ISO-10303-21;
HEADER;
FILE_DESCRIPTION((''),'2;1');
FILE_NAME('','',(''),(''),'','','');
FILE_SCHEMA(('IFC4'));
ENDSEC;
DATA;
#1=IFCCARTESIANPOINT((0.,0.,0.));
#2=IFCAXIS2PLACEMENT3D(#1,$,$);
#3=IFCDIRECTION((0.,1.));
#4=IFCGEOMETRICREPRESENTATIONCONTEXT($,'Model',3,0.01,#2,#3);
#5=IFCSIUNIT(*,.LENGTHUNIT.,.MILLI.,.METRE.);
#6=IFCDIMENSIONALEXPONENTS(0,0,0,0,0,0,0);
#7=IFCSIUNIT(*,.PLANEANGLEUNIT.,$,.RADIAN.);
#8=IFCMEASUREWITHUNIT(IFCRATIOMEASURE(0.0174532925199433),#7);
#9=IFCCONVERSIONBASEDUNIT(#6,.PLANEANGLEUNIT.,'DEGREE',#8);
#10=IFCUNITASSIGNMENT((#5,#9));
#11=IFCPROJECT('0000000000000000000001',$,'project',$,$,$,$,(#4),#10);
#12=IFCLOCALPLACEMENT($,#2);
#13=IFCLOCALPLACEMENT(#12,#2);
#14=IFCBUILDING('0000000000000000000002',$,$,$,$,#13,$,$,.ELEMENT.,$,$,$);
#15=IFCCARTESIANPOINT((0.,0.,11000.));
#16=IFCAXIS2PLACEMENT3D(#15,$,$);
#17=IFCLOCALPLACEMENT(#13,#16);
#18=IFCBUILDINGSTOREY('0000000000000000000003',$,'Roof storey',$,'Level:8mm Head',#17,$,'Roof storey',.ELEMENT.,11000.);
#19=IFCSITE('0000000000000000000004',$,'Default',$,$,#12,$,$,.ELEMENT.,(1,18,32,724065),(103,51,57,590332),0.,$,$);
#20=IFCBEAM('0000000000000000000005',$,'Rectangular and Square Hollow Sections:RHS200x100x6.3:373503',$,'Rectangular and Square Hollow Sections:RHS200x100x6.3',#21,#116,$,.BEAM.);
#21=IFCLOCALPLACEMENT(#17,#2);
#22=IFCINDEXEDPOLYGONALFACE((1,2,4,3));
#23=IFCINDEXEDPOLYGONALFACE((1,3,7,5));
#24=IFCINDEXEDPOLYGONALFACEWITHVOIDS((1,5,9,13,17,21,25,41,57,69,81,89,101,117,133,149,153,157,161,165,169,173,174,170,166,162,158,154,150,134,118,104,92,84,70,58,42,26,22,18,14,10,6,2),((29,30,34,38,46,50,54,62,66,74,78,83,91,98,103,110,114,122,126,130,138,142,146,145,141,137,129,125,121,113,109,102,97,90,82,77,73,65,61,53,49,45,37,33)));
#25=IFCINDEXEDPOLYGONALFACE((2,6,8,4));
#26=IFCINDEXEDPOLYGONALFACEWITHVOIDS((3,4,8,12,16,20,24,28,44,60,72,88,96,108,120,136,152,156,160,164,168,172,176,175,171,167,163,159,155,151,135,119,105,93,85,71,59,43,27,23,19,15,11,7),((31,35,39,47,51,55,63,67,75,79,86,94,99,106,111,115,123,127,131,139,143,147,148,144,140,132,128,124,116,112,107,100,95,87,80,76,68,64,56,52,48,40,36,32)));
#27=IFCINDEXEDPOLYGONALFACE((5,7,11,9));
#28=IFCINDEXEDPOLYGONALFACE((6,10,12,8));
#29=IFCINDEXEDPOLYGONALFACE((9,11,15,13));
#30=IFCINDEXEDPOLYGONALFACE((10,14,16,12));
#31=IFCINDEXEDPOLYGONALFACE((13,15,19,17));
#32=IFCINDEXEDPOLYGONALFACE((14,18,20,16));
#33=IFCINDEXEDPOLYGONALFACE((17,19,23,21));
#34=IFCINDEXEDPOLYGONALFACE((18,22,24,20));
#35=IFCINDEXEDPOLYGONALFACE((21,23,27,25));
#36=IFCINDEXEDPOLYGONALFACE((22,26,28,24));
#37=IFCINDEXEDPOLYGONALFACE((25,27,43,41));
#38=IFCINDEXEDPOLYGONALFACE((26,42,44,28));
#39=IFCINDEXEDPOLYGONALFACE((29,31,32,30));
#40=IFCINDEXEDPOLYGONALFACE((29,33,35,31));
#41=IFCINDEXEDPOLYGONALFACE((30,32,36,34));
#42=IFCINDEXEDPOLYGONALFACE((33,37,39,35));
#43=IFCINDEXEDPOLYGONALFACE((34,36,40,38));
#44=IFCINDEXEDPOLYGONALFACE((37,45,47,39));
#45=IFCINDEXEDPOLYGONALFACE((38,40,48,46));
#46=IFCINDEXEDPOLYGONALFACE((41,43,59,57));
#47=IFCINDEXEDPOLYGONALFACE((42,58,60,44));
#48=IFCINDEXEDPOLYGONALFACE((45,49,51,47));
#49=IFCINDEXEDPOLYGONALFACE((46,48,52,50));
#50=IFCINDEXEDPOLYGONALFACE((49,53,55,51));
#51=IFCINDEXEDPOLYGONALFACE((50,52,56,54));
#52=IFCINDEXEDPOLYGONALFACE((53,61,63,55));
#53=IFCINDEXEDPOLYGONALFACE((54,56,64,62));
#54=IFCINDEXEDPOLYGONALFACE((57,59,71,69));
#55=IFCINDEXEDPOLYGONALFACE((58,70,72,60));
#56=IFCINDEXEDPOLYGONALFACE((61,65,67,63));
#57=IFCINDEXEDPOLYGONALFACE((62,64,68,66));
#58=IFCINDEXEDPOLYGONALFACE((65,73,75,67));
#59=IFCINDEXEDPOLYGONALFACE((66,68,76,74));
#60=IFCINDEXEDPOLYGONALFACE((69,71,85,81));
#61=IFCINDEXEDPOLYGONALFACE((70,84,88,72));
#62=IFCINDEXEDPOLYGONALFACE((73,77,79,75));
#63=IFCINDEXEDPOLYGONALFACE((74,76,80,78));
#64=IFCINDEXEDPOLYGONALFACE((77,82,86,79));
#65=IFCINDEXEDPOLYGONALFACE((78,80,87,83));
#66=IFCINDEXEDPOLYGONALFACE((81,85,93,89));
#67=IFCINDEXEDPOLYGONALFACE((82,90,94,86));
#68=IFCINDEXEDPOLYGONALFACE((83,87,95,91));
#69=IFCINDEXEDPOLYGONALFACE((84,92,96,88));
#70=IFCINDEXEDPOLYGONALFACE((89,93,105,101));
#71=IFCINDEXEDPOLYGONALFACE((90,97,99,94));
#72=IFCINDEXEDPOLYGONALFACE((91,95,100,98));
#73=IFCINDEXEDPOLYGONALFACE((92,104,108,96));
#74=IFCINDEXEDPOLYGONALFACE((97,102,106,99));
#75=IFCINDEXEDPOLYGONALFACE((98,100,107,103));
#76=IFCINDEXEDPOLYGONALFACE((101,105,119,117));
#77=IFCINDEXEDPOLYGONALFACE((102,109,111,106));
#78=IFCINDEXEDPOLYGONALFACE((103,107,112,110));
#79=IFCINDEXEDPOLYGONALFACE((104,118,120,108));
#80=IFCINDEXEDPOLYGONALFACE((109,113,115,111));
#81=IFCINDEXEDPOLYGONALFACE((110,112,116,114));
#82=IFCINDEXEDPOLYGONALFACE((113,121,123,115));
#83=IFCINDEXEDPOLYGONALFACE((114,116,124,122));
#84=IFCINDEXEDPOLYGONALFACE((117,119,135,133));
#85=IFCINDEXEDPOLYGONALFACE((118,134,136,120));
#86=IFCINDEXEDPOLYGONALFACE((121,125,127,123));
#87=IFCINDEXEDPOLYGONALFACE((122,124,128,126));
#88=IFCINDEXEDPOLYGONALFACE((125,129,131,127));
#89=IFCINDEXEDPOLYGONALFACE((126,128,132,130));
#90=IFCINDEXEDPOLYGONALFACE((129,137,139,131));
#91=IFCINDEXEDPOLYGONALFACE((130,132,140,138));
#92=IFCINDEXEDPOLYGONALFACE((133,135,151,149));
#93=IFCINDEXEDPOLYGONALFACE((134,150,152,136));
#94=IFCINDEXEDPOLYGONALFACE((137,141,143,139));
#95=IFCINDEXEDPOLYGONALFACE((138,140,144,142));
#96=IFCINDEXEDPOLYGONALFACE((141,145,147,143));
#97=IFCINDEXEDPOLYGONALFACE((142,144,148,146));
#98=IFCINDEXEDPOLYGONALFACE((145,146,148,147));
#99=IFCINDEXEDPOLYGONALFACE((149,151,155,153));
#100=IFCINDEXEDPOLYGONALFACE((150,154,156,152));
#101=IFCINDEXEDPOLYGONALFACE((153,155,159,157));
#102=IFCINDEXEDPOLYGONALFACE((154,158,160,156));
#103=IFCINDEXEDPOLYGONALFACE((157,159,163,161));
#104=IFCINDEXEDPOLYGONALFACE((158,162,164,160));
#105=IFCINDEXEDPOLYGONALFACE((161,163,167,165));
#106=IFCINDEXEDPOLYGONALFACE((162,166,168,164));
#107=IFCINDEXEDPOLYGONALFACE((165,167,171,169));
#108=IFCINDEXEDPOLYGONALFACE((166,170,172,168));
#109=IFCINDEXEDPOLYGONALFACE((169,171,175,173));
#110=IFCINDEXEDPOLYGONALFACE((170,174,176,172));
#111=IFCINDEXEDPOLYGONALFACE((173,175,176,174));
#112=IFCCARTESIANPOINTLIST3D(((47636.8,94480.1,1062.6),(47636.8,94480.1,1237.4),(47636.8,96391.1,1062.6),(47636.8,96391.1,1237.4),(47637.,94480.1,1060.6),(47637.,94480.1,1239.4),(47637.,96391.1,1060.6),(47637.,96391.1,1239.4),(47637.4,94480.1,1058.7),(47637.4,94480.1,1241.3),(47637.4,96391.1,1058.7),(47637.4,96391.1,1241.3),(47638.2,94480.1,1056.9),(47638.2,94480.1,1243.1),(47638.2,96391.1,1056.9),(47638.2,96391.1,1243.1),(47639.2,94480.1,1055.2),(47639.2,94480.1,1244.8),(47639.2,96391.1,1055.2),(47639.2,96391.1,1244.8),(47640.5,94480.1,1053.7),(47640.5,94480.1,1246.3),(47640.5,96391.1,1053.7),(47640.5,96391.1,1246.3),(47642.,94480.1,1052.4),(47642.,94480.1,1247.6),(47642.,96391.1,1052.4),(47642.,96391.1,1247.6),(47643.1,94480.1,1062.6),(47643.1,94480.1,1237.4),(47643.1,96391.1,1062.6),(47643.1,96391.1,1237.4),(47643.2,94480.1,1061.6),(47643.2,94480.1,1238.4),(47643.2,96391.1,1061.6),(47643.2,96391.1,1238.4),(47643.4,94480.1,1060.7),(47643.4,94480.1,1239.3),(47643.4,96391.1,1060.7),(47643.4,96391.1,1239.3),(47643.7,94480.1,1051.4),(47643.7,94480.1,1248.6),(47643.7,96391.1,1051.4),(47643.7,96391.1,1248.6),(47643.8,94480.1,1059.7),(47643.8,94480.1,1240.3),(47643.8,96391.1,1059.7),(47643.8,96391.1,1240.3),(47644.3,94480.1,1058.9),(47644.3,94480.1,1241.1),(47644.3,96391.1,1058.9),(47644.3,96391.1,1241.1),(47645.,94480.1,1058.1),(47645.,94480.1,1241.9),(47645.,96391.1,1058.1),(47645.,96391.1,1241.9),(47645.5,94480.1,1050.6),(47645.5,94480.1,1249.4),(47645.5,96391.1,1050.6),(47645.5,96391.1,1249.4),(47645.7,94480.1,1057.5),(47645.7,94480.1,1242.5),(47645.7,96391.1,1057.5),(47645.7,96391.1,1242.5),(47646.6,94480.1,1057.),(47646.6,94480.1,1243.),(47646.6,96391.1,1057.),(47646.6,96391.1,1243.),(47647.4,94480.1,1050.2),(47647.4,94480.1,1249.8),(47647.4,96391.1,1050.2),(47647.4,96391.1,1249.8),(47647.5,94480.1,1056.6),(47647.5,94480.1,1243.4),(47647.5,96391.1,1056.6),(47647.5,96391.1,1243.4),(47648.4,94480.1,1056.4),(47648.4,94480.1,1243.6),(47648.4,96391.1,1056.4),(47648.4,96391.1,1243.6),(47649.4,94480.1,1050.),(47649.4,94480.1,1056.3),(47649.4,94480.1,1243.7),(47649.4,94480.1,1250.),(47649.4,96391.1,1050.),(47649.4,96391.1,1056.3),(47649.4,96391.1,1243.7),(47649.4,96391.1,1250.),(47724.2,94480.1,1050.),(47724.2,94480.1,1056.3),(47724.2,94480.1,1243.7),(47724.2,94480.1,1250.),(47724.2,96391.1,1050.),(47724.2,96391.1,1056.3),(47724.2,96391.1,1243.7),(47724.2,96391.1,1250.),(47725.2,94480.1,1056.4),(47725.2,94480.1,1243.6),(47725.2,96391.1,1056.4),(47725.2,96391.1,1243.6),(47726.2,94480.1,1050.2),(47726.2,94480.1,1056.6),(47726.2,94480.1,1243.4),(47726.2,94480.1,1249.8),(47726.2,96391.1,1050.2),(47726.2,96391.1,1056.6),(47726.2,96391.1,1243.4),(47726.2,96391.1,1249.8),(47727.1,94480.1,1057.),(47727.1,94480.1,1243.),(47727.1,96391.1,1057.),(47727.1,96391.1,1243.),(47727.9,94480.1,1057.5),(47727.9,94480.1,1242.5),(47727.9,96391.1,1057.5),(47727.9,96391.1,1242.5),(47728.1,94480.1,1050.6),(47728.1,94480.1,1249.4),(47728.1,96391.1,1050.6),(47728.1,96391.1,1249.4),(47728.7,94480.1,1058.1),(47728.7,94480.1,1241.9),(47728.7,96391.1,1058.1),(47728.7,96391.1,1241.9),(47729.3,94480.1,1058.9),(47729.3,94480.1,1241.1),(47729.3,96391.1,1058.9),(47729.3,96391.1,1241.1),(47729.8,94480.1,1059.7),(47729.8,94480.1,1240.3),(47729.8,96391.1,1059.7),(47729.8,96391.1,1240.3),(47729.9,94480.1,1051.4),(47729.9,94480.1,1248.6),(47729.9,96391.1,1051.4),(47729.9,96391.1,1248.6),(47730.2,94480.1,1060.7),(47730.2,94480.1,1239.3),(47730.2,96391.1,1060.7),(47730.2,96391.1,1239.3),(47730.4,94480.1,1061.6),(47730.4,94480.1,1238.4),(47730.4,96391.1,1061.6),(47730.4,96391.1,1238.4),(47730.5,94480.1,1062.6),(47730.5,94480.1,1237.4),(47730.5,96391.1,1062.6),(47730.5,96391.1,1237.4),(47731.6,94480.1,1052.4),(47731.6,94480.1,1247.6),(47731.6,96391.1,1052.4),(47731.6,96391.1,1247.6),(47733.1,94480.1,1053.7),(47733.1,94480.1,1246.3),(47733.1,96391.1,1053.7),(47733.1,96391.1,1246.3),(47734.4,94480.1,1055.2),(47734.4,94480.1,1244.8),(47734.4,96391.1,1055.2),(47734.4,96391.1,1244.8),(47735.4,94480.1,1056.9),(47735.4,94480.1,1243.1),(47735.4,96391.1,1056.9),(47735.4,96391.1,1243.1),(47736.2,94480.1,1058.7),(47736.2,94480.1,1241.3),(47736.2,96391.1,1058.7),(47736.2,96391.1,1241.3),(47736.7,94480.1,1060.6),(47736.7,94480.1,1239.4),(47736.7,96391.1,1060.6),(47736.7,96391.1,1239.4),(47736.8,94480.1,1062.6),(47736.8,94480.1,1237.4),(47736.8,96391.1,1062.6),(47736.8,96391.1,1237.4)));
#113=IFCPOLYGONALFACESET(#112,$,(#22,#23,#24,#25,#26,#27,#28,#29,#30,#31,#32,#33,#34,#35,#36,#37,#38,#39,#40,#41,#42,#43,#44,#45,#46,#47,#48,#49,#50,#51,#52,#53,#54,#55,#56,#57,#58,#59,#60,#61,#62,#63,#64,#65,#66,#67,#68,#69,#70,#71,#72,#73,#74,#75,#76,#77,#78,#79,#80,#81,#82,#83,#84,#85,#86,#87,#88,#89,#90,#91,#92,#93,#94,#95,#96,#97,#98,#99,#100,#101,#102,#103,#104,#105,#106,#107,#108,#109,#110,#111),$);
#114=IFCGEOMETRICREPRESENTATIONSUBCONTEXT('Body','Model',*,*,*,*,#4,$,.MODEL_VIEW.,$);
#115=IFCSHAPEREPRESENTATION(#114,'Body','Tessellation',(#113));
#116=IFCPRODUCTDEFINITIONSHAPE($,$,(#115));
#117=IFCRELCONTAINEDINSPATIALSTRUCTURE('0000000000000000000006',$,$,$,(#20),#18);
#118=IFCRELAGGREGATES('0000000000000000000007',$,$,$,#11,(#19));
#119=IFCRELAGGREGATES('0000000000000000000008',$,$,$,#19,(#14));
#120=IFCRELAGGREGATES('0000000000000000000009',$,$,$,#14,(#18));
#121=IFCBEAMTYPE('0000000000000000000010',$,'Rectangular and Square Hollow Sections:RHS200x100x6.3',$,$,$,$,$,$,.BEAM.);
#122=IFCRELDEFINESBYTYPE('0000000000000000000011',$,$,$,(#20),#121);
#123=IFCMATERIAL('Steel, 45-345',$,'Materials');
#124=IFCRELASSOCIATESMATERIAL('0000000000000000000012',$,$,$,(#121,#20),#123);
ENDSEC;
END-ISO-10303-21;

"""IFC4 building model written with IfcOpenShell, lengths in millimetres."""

from ifc_helpers import new_model, entity, si_unit, converted_unit, direction, frame, origin, place, context, subcontext, project, spatial, indexed_curve, outline, extrude, source, transform, mapped, material, type_object, type_shapes, element, save


model = new_model("IFC4")

# Units and contexts
model_context = context("Model", 3, precision=0.01, world=origin(), true_north=direction((0.0, 1.0)))
body_context = subcontext(model_context, "Body", "Model", "MODEL_VIEW")
ifc_project = project(units=[si_unit("LENGTHUNIT", "METRE", prefix="MILLI"), converted_unit("PLANEANGLEUNIT", "DEGREE", entity("IfcRatioMeasure", 0.0174532925199433), si_unit("PLANEANGLEUNIT", "RADIAN"), dimensions=[0, 0, 0, 0, 0, 0, 0])], contexts=[model_context])

# Site, building, storey
site_placement = place(None, origin())
site = spatial("IfcSite", under=ifc_project, at=site_placement, Name="Default", CompositionType="ELEMENT", RefLatitude=(1, 18, 32, 724065), RefLongitude=(103, 51, 57, 590332), RefElevation=0.0)
building_placement = place(site_placement, origin())
building = spatial("IfcBuilding", under=site, at=building_placement, CompositionType="ELEMENT")
storey_placement = place(building_placement, frame((0.0, 0.0, 11000.0)))
storey = spatial("IfcBuildingStorey", under=building, at=storey_placement, Name="Roof storey", ObjectType="Level:8mm Head", LongName="Roof storey", CompositionType="ELEMENT", Elevation=11000.0)

# Shared definitions
ifc_material = material(Name="Steel, 45-345", Category="Materials")

# Beam
beam_type_1 = type_object("IfcBeamType", Name="Rectangular and Square Hollow Sections:RHS200x100x6.3", PredefinedType="BEAM", material=ifc_material)
shared_shape_1 = source(origin(), body_context, "Body", "SweptSolid", [
    extrude(outline(indexed_curve([(-50.0, -87.4), (-49.8, -89.4), (-49.4, -91.3), (-48.6, -93.1), (-47.6, -94.8), (-46.3, -96.3), (-44.8, -97.6), (-43.1, -98.6), (-41.3, -99.4), (-39.4, -99.8), (-37.4, -100.0), (37.4, -100.0), (39.4, -99.8), (41.3, -99.4), (43.1, -98.6), (44.8, -97.6), (46.3, -96.3), (47.6, -94.8), (48.6, -93.1), (49.4, -91.3), (49.8, -89.4), (50.0, -87.4), (50.0, 87.4), (49.8, 89.4), (49.4, 91.3), (48.6, 93.1), (47.6, 94.8), (46.3, 96.3), (44.8, 97.6), (43.1, 98.6), (41.3, 99.4), (39.4, 99.8), (37.4, 100.0), (-37.4, 100.0), (-39.4, 99.8), (-41.3, 99.4), (-43.1, 98.6), (-44.8, 97.6), (-46.3, 96.3), (-47.6, 94.8), (-48.6, 93.1), (-49.4, 91.3), (-49.8, 89.4), (-50.0, 87.4), (-50.0, -87.4)], self_intersect=False), holes=[indexed_curve([(37.4, -93.7), (-37.4, -93.7), (-38.4, -93.6), (-39.3, -93.4), (-40.3, -93.0), (-41.1, -92.5), (-41.9, -91.9), (-42.5, -91.1), (-43.0, -90.3), (-43.4, -89.3), (-43.6, -88.4), (-43.7, -87.4), (-43.7, 87.4), (-43.6, 88.4), (-43.4, 89.3), (-43.0, 90.3), (-42.5, 91.1), (-41.9, 91.9), (-41.1, 92.5), (-40.3, 93.0), (-39.3, 93.4), (-38.4, 93.6), (-37.4, 93.7), (37.4, 93.7), (38.4, 93.6), (39.3, 93.4), (40.3, 93.0), (41.1, 92.5), (41.9, 91.9), (42.5, 91.1), (43.0, 90.3), (43.4, 89.3), (43.6, 88.4), (43.7, 87.4), (43.7, -87.4), (43.6, -88.4), (43.4, -89.3), (43.0, -90.3), (42.5, -91.1), (41.9, -91.9), (41.1, -92.5), (40.3, -93.0), (39.3, -93.4), (38.4, -93.6), (37.4, -93.7)], self_intersect=False)]), frame((-1014.5, 0.0, 0.0), z_axis=(1.0, 0.0, 0.0), x_axis=(0.0, -1.0, 0.0)), (0.0, 0.0, 1.0), 1911.0),
])
type_shapes(beam_type_1, [shared_shape_1])
beam_1_placement = place(storey_placement, frame((47686.8, 95494.6, 1150.0), z_axis=(0.0, 0.0, 1.0), x_axis=(0.0, 1.0, 0.0)))
element("IfcBeam", 1, at=beam_1_placement, inside=storey, type_object=beam_type_1, material=ifc_material, Name="Rectangular and Square Hollow Sections:RHS200x100x6.3:373503", ObjectType="Rectangular and Square Hollow Sections:RHS200x100x6.3", PredefinedType="BEAM", context=body_context, shape_type="MappedRepresentation", body=[
    mapped(shared_shape_1, transform((0.0, 0.0, 0.0), scale=1.0)),
])

save(model, "model.ifc")
